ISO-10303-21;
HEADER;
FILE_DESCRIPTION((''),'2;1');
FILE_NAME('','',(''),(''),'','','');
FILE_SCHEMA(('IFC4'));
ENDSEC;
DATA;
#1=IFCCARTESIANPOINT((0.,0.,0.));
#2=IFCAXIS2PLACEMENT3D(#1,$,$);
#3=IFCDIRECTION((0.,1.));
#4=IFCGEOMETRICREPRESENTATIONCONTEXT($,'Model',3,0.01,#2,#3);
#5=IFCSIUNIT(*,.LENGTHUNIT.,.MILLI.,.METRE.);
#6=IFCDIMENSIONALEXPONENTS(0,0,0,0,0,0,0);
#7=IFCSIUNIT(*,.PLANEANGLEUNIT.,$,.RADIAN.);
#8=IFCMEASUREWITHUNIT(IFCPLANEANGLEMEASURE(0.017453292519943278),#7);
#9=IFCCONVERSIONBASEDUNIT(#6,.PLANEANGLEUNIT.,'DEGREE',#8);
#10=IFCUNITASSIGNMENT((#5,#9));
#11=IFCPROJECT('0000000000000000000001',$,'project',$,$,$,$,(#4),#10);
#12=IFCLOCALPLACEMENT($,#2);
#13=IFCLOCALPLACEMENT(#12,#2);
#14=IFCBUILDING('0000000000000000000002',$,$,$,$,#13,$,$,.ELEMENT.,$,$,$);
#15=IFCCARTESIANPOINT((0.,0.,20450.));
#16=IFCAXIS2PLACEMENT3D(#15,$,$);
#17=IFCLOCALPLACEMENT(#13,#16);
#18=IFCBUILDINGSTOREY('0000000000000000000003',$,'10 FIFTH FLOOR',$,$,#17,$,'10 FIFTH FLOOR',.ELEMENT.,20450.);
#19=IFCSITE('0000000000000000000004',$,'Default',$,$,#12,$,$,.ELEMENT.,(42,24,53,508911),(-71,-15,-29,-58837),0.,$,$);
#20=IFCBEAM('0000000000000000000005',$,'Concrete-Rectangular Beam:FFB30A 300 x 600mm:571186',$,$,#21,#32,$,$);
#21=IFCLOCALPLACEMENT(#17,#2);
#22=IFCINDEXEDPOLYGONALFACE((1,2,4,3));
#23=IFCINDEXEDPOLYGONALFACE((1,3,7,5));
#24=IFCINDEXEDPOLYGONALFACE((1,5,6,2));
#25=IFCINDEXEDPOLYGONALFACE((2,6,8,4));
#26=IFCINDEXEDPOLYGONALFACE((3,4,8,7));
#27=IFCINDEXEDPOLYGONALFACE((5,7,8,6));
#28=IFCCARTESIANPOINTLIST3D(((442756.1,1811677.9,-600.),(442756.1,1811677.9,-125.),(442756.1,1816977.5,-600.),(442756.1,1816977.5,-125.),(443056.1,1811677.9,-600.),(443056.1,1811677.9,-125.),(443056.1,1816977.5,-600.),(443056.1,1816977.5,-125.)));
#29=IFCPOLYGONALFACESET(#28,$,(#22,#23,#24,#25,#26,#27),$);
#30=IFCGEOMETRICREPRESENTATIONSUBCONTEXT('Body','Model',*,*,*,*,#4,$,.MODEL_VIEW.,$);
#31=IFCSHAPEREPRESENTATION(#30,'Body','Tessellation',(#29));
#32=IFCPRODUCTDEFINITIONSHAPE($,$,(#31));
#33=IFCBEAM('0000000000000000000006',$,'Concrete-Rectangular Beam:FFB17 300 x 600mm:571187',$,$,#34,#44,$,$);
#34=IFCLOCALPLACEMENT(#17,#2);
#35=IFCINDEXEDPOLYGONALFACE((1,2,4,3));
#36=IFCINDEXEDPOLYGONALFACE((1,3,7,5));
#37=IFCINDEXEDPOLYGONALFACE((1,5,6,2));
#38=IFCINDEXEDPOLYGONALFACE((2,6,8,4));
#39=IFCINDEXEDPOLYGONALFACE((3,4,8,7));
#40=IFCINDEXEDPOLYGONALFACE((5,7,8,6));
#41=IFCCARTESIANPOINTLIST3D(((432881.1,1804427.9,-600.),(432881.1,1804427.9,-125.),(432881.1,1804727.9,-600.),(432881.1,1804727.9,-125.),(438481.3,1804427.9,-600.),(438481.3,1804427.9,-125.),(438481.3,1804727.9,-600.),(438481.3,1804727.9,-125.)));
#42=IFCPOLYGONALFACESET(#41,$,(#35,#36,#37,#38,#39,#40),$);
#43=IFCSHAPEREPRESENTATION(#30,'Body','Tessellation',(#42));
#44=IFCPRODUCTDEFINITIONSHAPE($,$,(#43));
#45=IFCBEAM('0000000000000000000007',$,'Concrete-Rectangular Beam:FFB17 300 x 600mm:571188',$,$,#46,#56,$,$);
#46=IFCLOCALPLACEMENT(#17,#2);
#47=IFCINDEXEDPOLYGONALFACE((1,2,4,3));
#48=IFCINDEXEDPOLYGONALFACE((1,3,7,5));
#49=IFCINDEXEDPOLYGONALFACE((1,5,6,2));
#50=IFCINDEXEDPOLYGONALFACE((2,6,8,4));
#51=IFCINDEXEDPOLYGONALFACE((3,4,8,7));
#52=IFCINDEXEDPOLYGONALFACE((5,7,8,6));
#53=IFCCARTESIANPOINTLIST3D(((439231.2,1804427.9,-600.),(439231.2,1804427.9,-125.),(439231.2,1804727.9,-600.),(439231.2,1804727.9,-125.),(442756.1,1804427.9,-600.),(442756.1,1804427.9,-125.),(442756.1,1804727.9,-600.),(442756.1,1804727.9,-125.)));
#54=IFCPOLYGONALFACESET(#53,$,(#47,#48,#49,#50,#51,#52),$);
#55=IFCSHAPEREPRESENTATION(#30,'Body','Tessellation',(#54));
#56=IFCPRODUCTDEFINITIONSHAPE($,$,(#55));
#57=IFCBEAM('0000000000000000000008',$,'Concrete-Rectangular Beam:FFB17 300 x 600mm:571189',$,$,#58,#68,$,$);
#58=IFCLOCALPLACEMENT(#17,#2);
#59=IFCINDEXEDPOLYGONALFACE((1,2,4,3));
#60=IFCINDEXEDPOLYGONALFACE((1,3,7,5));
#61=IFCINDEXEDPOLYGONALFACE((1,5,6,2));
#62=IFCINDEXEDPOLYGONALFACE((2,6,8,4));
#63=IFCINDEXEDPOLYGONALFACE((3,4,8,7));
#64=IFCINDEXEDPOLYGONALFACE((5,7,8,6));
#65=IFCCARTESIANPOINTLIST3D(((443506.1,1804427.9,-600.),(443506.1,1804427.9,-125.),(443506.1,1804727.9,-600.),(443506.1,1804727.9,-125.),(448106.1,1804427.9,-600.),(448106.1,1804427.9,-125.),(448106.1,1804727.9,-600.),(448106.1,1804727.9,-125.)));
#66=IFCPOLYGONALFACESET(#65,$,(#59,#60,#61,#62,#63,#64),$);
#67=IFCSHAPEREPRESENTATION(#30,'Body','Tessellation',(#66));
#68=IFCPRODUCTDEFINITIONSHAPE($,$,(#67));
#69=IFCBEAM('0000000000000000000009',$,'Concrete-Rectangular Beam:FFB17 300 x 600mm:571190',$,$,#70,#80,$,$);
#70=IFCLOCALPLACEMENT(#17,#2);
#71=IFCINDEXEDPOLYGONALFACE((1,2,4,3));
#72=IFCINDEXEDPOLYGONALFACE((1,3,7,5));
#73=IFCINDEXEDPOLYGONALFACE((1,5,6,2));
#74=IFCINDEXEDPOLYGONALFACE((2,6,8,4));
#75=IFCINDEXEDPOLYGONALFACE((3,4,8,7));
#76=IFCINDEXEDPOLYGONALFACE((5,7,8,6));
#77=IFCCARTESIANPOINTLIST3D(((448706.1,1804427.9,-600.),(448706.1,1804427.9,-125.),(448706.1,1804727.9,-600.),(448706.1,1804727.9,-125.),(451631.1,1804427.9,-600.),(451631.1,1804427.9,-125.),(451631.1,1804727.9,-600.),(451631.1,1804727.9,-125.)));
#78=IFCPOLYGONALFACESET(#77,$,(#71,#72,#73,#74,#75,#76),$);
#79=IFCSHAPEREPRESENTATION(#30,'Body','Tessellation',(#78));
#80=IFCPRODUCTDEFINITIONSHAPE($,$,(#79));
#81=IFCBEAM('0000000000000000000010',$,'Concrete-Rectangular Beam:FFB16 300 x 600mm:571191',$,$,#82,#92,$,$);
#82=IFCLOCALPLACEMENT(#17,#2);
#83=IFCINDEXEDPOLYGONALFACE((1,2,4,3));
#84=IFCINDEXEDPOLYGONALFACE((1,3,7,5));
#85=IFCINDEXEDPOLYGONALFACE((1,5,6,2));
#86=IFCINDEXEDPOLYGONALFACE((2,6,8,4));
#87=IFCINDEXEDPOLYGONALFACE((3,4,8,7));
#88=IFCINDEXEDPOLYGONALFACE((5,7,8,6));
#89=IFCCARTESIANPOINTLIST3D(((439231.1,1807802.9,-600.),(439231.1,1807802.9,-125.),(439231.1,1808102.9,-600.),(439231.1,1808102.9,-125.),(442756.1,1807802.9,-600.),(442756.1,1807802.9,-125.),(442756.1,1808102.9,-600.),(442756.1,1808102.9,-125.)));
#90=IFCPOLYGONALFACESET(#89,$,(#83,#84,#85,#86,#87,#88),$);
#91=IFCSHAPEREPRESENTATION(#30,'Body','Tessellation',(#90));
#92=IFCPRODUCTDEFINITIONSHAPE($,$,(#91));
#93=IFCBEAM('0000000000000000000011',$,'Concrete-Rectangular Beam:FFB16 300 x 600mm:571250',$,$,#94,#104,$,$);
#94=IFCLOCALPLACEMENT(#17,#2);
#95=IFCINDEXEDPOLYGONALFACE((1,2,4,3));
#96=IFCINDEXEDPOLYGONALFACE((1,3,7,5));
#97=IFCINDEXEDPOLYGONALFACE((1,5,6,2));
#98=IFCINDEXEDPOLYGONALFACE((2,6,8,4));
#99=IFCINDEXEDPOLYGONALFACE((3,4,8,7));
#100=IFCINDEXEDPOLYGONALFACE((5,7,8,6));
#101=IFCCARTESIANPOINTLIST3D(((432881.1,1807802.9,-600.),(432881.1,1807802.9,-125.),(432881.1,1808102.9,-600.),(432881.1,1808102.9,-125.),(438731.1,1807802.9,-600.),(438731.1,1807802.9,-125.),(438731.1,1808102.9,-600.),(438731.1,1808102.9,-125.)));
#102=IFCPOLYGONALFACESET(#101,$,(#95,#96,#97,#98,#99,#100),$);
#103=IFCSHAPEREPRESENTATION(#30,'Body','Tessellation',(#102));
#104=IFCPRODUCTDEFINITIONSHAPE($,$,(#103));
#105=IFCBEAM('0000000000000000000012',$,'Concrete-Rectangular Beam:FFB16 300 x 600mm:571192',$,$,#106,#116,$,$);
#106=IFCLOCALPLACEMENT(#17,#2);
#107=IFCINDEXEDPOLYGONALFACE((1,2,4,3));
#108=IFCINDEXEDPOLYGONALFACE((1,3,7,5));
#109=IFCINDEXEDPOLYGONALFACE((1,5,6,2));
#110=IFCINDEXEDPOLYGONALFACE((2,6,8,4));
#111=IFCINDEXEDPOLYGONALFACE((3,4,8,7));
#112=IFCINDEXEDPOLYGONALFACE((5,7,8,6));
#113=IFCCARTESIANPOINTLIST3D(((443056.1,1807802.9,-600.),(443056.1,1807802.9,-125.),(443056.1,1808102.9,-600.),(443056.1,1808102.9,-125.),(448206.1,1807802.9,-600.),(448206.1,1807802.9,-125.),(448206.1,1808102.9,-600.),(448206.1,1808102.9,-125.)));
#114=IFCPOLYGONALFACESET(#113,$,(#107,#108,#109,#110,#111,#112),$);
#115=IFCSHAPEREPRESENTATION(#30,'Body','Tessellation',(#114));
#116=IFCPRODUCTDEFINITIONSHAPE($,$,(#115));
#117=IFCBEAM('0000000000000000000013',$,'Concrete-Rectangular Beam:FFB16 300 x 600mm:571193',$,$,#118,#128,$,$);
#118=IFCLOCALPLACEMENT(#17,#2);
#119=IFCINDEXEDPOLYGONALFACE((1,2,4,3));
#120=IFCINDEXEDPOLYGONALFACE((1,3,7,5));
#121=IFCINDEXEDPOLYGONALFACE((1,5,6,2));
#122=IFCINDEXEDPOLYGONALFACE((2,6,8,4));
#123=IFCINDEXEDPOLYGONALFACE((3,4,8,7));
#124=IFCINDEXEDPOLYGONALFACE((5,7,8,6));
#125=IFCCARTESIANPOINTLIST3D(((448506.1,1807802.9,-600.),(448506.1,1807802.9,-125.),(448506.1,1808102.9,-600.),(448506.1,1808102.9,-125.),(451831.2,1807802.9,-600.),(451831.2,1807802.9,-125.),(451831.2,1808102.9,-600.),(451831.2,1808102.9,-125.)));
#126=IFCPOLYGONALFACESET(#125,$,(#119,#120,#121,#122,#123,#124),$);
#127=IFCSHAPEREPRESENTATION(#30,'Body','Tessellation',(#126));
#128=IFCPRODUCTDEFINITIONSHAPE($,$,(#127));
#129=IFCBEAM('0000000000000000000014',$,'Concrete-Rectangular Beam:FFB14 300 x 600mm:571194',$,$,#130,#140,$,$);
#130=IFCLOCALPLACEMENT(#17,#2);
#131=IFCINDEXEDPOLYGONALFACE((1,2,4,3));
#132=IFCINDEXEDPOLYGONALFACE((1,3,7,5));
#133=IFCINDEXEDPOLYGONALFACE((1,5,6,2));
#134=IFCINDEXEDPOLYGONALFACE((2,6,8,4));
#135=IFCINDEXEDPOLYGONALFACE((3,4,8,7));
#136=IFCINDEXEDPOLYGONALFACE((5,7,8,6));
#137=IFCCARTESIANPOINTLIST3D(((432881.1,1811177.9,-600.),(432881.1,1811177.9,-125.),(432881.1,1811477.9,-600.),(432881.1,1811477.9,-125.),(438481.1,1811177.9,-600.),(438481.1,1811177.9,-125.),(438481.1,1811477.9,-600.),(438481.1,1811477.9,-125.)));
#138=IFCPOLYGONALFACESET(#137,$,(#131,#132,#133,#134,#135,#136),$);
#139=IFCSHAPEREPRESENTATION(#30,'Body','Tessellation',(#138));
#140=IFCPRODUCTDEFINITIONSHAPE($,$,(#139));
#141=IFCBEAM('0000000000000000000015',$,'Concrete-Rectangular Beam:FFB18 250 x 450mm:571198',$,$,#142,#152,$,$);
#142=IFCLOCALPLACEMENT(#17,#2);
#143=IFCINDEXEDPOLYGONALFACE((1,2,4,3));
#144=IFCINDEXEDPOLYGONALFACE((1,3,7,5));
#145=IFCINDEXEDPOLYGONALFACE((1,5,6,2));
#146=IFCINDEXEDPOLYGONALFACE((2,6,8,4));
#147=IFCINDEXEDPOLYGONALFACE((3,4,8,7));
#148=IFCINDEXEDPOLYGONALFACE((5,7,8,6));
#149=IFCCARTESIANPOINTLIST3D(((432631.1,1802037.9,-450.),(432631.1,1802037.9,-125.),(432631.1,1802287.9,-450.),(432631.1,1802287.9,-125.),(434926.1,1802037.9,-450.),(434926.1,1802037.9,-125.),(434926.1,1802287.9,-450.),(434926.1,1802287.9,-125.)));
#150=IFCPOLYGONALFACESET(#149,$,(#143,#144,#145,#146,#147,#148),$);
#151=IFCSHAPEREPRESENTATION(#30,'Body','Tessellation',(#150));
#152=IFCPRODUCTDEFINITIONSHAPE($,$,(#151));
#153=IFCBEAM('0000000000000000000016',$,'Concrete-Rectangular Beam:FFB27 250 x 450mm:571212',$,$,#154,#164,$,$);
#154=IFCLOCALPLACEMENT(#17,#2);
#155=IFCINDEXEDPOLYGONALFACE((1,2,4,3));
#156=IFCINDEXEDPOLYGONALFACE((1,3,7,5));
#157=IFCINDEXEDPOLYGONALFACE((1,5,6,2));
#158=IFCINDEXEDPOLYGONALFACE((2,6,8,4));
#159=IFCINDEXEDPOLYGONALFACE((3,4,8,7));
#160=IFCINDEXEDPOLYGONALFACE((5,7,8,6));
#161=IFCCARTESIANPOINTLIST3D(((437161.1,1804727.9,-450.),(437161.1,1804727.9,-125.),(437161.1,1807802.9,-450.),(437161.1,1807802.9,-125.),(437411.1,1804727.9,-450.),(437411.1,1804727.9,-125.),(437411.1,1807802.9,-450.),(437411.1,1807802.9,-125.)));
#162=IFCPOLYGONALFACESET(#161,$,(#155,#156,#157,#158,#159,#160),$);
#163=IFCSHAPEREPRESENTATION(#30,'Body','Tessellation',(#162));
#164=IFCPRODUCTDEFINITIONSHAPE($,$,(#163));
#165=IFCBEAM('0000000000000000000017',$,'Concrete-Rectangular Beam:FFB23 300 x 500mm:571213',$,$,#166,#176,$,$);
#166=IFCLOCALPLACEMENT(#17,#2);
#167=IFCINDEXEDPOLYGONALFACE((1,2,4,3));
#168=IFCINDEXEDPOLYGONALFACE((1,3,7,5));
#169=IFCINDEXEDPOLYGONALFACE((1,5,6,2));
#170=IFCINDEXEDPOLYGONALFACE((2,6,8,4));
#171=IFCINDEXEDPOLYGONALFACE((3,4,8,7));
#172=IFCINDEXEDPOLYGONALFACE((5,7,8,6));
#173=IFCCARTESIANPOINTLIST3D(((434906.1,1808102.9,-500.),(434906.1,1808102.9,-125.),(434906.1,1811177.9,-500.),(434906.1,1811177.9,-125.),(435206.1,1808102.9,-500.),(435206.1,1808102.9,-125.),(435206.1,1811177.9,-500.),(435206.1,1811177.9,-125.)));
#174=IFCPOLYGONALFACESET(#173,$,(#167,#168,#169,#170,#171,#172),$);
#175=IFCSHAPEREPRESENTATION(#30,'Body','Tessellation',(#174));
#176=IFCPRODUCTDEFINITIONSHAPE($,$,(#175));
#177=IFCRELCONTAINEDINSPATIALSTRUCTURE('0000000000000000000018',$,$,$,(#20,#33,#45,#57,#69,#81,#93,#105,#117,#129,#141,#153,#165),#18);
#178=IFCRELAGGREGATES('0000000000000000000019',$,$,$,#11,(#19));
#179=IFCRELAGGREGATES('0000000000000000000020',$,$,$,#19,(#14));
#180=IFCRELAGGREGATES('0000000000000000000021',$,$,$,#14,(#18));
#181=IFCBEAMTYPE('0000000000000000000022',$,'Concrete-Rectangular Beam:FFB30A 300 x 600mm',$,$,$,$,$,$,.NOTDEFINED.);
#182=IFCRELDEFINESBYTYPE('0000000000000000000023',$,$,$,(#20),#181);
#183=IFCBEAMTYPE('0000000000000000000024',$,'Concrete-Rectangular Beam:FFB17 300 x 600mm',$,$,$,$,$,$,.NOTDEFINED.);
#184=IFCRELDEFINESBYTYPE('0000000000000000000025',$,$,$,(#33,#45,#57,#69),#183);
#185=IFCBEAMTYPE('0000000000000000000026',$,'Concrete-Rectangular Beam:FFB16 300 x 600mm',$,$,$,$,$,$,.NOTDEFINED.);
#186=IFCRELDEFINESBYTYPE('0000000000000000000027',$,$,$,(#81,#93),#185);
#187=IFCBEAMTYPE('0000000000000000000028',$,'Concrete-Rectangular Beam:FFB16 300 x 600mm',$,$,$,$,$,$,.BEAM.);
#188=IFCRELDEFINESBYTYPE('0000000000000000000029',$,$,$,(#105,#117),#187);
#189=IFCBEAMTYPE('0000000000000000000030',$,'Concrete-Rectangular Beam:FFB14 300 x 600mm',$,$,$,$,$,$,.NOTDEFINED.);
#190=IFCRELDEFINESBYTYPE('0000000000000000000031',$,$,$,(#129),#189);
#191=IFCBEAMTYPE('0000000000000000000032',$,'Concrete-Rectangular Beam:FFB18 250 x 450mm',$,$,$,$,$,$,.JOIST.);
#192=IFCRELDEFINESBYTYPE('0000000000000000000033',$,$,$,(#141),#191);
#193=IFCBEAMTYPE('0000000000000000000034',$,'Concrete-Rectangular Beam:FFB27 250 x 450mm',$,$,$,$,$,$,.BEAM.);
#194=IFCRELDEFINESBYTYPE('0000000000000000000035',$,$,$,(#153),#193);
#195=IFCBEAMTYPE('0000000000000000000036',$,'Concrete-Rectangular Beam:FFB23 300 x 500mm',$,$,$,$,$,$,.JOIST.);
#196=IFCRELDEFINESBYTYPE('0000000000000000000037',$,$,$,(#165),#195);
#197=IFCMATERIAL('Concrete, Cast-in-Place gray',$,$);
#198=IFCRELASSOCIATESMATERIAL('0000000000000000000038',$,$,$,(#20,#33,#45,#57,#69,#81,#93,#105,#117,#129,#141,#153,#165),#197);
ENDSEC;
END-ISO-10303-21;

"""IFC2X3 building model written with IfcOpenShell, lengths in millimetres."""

from ifc_helpers import new_model, entity, si_unit, converted_unit, direction, frame, frame_2d, origin, place, context, subcontext, project, spatial, rectangle, extrude, material, type_object, element, save


model = new_model("IFC2X3")

# Units and contexts
model_context = context("Model", 3, precision=0.01, world=origin(), true_north=direction((0.0, 1.0)))
body_context = subcontext(model_context, "Body", "Model", "MODEL_VIEW")
ifc_project = project(units=[si_unit("LENGTHUNIT", "METRE", prefix="MILLI"), converted_unit("PLANEANGLEUNIT", "DEGREE", entity("IfcPlaneAngleMeasure", 0.017453292519943278), si_unit("PLANEANGLEUNIT", "RADIAN"), dimensions=[0, 0, 0, 0, 0, 0, 0])], contexts=[model_context])

# Site, building, storey
site_placement = place(None, origin())
site = spatial("IfcSite", under=ifc_project, at=site_placement, Name="Default", CompositionType="ELEMENT", RefLatitude=(42, 24, 53, 508911), RefLongitude=(-71, -15, -29, -58837), RefElevation=0.0)
building_placement = place(site_placement, origin())
building = spatial("IfcBuilding", under=site, at=building_placement, CompositionType="ELEMENT")
storey_placement = place(building_placement, frame((0.0, 0.0, 20450.0)))
storey = spatial("IfcBuildingStorey", under=building, at=storey_placement, Name="10 FIFTH FLOOR", LongName="10 FIFTH FLOOR", CompositionType="ELEMENT", Elevation=20450.0)

# Beams
ifc_material = material(Name="Concrete, Cast-in-Place gray")
beam_type_1 = type_object("IfcBeamType", Name="Concrete-Rectangular Beam:FFB30A 300 x 600mm", PredefinedType="NOTDEFINED")
beam_1_placement = place(storey_placement, frame((442756.1, 1811677.9, 0.0), z_axis=(0.0, 0.0, 1.0), x_axis=(0.0, 1.0, 0.0)))
element("IfcBeam", 1, at=beam_1_placement, inside=storey, type_object=beam_type_1, material=ifc_material, Name="Concrete-Rectangular Beam:FFB30A 300 x 600mm:571186", context=body_context, shape_type="SweptSolid", body=[
    extrude(rectangle(XDim=475.0, YDim=300.0, at=frame_2d((0.0, 0.0), x_axis=(1.0, 0.0))), frame((0.0, -150.0, -362.5), z_axis=(1.0, 0.0, 0.0), x_axis=(0.0, 0.0, -1.0)), (0.0, 0.0, 1.0), 5299.6),
])
beam_type_2 = type_object("IfcBeamType", Name="Concrete-Rectangular Beam:FFB17 300 x 600mm", PredefinedType="NOTDEFINED")
beam_2_placement = place(storey_placement, frame((432881.1, 1804727.9, 0.0)))
element("IfcBeam", 2, at=beam_2_placement, inside=storey, type_object=beam_type_2, material=ifc_material, Name="Concrete-Rectangular Beam:FFB17 300 x 600mm:571187", context=body_context, shape_type="SweptSolid", body=[
    extrude(rectangle(XDim=475.0, YDim=300.0, at=frame_2d((0.0, 0.0), x_axis=(1.0, 0.0))), frame((0.0, -150.0, -362.5), z_axis=(1.0, 0.0, 0.0), x_axis=(0.0, 0.0, -1.0)), (0.0, 0.0, 1.0), 5600.2),
])
beam_3_placement = place(storey_placement, frame((439231.2, 1804727.9, 0.0)))
element("IfcBeam", 3, at=beam_3_placement, inside=storey, type_object=beam_type_2, material=ifc_material, Name="Concrete-Rectangular Beam:FFB17 300 x 600mm:571188", context=body_context, shape_type="SweptSolid", body=[
    extrude(rectangle(XDim=475.0, YDim=300.0, at=frame_2d((0.0, 0.0), x_axis=(1.0, 0.0))), frame((0.0, -150.0, -362.5), z_axis=(1.0, 0.0, 0.0), x_axis=(0.0, 0.0, -1.0)), (0.0, 0.0, 1.0), 3524.9),
])
beam_4_placement = place(storey_placement, frame((443506.1, 1804727.9, 0.0)))
element("IfcBeam", 4, at=beam_4_placement, inside=storey, type_object=beam_type_2, material=ifc_material, Name="Concrete-Rectangular Beam:FFB17 300 x 600mm:571189", context=body_context, shape_type="SweptSolid", body=[
    extrude(rectangle(XDim=475.0, YDim=300.0, at=frame_2d((0.0, 0.0), x_axis=(1.0, 0.0))), frame((0.0, -150.0, -362.5), z_axis=(1.0, 0.0, 0.0), x_axis=(0.0, 0.0, -1.0)), (0.0, 0.0, 1.0), 4600.0),
])
beam_5_placement = place(storey_placement, frame((448706.1, 1804727.9, 0.0)))
element("IfcBeam", 5, at=beam_5_placement, inside=storey, type_object=beam_type_2, material=ifc_material, Name="Concrete-Rectangular Beam:FFB17 300 x 600mm:571190", context=body_context, shape_type="SweptSolid", body=[
    extrude(rectangle(XDim=475.0, YDim=300.0, at=frame_2d((0.0, 0.0), x_axis=(1.0, 0.0))), frame((0.0, -150.0, -362.5), z_axis=(1.0, 0.0, 0.0), x_axis=(0.0, 0.0, -1.0)), (0.0, 0.0, 1.0), 2925.0),
])
beam_type_3 = type_object("IfcBeamType", Name="Concrete-Rectangular Beam:FFB16 300 x 600mm", PredefinedType="NOTDEFINED")
beam_6_placement = place(storey_placement, frame((439231.1, 1808102.9, 0.0)))
element("IfcBeam", 6, at=beam_6_placement, inside=storey, type_object=beam_type_3, material=ifc_material, Name="Concrete-Rectangular Beam:FFB16 300 x 600mm:571191", context=body_context, shape_type="SweptSolid", body=[
    extrude(rectangle(XDim=475.0, YDim=300.0, at=frame_2d((0.0, 0.0), x_axis=(1.0, 0.0))), frame((0.0, -150.0, -362.5), z_axis=(1.0, 0.0, 0.0), x_axis=(0.0, 0.0, -1.0)), (0.0, 0.0, 1.0), 3525.0),
])
beam_7_placement = place(storey_placement, frame((432881.1, 1808102.9, 0.0)))
element("IfcBeam", 7, at=beam_7_placement, inside=storey, type_object=beam_type_3, material=ifc_material, Name="Concrete-Rectangular Beam:FFB16 300 x 600mm:571250", context=body_context, shape_type="SweptSolid", body=[
    extrude(rectangle(XDim=475.0, YDim=300.0, at=frame_2d((0.0, 0.0), x_axis=(1.0, 0.0))), frame((0.0, -150.0, -362.5), z_axis=(1.0, 0.0, 0.0), x_axis=(0.0, 0.0, -1.0)), (0.0, 0.0, 1.0), 5850.0),
])
beam_type_4 = type_object("IfcBeamType", Name="Concrete-Rectangular Beam:FFB16 300 x 600mm", PredefinedType="BEAM")
beam_8_placement = place(storey_placement, frame((443056.1, 1808102.9, 0.0)))
element("IfcBeam", 8, at=beam_8_placement, inside=storey, type_object=beam_type_4, material=ifc_material, Name="Concrete-Rectangular Beam:FFB16 300 x 600mm:571192", context=body_context, shape_type="SweptSolid", body=[
    extrude(rectangle(XDim=475.0, YDim=300.0, at=frame_2d((0.0, 0.0), x_axis=(1.0, 0.0))), frame((0.0, -150.0, -362.5), z_axis=(1.0, 0.0, 0.0), x_axis=(0.0, 0.0, -1.0)), (0.0, 0.0, 1.0), 5150.0),
])
beam_9_placement = place(storey_placement, frame((448506.1, 1808102.9, 0.0)))
element("IfcBeam", 9, at=beam_9_placement, inside=storey, type_object=beam_type_4, material=ifc_material, Name="Concrete-Rectangular Beam:FFB16 300 x 600mm:571193", context=body_context, shape_type="SweptSolid", body=[
    extrude(rectangle(XDim=475.0, YDim=300.0, at=frame_2d((0.0, 0.0), x_axis=(1.0, 0.0))), frame((0.0, -150.0, -362.5), z_axis=(1.0, 0.0, 0.0), x_axis=(0.0, 0.0, -1.0)), (0.0, 0.0, 1.0), 3325.1),
])
beam_type_5 = type_object("IfcBeamType", Name="Concrete-Rectangular Beam:FFB14 300 x 600mm", PredefinedType="NOTDEFINED")
beam_10_placement = place(storey_placement, frame((432881.1, 1811177.9, 0.0)))
element("IfcBeam", 10, at=beam_10_placement, inside=storey, type_object=beam_type_5, material=ifc_material, Name="Concrete-Rectangular Beam:FFB14 300 x 600mm:571194", context=body_context, shape_type="SweptSolid", body=[
    extrude(rectangle(XDim=475.0, YDim=300.0, at=frame_2d((0.0, 0.0), x_axis=(1.0, 0.0))), frame((0.0, 150.0, -362.5), z_axis=(1.0, 0.0, 0.0), x_axis=(0.0, 0.0, -1.0)), (0.0, 0.0, 1.0), 5600.0),
])
beam_type_6 = type_object("IfcBeamType", Name="Concrete-Rectangular Beam:FFB18 250 x 450mm", PredefinedType="JOIST")
beam_11_placement = place(storey_placement, frame((432631.1, 1802287.9, 0.0)))
element("IfcBeam", 11, at=beam_11_placement, inside=storey, type_object=beam_type_6, material=ifc_material, Name="Concrete-Rectangular Beam:FFB18 250 x 450mm:571198", context=body_context, shape_type="SweptSolid", body=[
    extrude(rectangle(XDim=325.0, YDim=250.0, at=frame_2d((0.0, 0.0), x_axis=(1.0, 0.0))), frame((0.0, -125.0, -287.5), z_axis=(1.0, 0.0, 0.0), x_axis=(0.0, 0.0, -1.0)), (0.0, 0.0, 1.0), 2295.0),
])
beam_type_7 = type_object("IfcBeamType", Name="Concrete-Rectangular Beam:FFB27 250 x 450mm", PredefinedType="BEAM")
beam_12_placement = place(storey_placement, frame((437161.1, 1807802.9, 0.0), z_axis=(0.0, 0.0, 1.0), x_axis=(0.0, -1.0, 0.0)))
element("IfcBeam", 12, at=beam_12_placement, inside=storey, type_object=beam_type_7, material=ifc_material, Name="Concrete-Rectangular Beam:FFB27 250 x 450mm:571212", context=body_context, shape_type="SweptSolid", body=[
    extrude(rectangle(XDim=325.0, YDim=250.0, at=frame_2d((0.0, 0.0), x_axis=(1.0, 0.0))), frame((0.0, 125.0, -287.5), z_axis=(1.0, 0.0, 0.0), x_axis=(0.0, 0.0, -1.0)), (0.0, 0.0, 1.0), 3075.0),
])
beam_type_8 = type_object("IfcBeamType", Name="Concrete-Rectangular Beam:FFB23 300 x 500mm", PredefinedType="JOIST")
beam_13_placement = place(storey_placement, frame((434906.1, 1811177.9, 0.0), z_axis=(0.0, 0.0, 1.0), x_axis=(0.0, -1.0, 0.0)))
element("IfcBeam", 13, at=beam_13_placement, inside=storey, type_object=beam_type_8, material=ifc_material, Name="Concrete-Rectangular Beam:FFB23 300 x 500mm:571213", context=body_context, shape_type="SweptSolid", body=[
    extrude(rectangle(XDim=375.0, YDim=300.0, at=frame_2d((0.0, 0.0), x_axis=(1.0, 0.0))), frame((0.0, 150.0, -312.5), z_axis=(1.0, 0.0, 0.0), x_axis=(0.0, 0.0, -1.0)), (0.0, 0.0, 1.0), 3075.0),
])

save(model, "model.ifc")
